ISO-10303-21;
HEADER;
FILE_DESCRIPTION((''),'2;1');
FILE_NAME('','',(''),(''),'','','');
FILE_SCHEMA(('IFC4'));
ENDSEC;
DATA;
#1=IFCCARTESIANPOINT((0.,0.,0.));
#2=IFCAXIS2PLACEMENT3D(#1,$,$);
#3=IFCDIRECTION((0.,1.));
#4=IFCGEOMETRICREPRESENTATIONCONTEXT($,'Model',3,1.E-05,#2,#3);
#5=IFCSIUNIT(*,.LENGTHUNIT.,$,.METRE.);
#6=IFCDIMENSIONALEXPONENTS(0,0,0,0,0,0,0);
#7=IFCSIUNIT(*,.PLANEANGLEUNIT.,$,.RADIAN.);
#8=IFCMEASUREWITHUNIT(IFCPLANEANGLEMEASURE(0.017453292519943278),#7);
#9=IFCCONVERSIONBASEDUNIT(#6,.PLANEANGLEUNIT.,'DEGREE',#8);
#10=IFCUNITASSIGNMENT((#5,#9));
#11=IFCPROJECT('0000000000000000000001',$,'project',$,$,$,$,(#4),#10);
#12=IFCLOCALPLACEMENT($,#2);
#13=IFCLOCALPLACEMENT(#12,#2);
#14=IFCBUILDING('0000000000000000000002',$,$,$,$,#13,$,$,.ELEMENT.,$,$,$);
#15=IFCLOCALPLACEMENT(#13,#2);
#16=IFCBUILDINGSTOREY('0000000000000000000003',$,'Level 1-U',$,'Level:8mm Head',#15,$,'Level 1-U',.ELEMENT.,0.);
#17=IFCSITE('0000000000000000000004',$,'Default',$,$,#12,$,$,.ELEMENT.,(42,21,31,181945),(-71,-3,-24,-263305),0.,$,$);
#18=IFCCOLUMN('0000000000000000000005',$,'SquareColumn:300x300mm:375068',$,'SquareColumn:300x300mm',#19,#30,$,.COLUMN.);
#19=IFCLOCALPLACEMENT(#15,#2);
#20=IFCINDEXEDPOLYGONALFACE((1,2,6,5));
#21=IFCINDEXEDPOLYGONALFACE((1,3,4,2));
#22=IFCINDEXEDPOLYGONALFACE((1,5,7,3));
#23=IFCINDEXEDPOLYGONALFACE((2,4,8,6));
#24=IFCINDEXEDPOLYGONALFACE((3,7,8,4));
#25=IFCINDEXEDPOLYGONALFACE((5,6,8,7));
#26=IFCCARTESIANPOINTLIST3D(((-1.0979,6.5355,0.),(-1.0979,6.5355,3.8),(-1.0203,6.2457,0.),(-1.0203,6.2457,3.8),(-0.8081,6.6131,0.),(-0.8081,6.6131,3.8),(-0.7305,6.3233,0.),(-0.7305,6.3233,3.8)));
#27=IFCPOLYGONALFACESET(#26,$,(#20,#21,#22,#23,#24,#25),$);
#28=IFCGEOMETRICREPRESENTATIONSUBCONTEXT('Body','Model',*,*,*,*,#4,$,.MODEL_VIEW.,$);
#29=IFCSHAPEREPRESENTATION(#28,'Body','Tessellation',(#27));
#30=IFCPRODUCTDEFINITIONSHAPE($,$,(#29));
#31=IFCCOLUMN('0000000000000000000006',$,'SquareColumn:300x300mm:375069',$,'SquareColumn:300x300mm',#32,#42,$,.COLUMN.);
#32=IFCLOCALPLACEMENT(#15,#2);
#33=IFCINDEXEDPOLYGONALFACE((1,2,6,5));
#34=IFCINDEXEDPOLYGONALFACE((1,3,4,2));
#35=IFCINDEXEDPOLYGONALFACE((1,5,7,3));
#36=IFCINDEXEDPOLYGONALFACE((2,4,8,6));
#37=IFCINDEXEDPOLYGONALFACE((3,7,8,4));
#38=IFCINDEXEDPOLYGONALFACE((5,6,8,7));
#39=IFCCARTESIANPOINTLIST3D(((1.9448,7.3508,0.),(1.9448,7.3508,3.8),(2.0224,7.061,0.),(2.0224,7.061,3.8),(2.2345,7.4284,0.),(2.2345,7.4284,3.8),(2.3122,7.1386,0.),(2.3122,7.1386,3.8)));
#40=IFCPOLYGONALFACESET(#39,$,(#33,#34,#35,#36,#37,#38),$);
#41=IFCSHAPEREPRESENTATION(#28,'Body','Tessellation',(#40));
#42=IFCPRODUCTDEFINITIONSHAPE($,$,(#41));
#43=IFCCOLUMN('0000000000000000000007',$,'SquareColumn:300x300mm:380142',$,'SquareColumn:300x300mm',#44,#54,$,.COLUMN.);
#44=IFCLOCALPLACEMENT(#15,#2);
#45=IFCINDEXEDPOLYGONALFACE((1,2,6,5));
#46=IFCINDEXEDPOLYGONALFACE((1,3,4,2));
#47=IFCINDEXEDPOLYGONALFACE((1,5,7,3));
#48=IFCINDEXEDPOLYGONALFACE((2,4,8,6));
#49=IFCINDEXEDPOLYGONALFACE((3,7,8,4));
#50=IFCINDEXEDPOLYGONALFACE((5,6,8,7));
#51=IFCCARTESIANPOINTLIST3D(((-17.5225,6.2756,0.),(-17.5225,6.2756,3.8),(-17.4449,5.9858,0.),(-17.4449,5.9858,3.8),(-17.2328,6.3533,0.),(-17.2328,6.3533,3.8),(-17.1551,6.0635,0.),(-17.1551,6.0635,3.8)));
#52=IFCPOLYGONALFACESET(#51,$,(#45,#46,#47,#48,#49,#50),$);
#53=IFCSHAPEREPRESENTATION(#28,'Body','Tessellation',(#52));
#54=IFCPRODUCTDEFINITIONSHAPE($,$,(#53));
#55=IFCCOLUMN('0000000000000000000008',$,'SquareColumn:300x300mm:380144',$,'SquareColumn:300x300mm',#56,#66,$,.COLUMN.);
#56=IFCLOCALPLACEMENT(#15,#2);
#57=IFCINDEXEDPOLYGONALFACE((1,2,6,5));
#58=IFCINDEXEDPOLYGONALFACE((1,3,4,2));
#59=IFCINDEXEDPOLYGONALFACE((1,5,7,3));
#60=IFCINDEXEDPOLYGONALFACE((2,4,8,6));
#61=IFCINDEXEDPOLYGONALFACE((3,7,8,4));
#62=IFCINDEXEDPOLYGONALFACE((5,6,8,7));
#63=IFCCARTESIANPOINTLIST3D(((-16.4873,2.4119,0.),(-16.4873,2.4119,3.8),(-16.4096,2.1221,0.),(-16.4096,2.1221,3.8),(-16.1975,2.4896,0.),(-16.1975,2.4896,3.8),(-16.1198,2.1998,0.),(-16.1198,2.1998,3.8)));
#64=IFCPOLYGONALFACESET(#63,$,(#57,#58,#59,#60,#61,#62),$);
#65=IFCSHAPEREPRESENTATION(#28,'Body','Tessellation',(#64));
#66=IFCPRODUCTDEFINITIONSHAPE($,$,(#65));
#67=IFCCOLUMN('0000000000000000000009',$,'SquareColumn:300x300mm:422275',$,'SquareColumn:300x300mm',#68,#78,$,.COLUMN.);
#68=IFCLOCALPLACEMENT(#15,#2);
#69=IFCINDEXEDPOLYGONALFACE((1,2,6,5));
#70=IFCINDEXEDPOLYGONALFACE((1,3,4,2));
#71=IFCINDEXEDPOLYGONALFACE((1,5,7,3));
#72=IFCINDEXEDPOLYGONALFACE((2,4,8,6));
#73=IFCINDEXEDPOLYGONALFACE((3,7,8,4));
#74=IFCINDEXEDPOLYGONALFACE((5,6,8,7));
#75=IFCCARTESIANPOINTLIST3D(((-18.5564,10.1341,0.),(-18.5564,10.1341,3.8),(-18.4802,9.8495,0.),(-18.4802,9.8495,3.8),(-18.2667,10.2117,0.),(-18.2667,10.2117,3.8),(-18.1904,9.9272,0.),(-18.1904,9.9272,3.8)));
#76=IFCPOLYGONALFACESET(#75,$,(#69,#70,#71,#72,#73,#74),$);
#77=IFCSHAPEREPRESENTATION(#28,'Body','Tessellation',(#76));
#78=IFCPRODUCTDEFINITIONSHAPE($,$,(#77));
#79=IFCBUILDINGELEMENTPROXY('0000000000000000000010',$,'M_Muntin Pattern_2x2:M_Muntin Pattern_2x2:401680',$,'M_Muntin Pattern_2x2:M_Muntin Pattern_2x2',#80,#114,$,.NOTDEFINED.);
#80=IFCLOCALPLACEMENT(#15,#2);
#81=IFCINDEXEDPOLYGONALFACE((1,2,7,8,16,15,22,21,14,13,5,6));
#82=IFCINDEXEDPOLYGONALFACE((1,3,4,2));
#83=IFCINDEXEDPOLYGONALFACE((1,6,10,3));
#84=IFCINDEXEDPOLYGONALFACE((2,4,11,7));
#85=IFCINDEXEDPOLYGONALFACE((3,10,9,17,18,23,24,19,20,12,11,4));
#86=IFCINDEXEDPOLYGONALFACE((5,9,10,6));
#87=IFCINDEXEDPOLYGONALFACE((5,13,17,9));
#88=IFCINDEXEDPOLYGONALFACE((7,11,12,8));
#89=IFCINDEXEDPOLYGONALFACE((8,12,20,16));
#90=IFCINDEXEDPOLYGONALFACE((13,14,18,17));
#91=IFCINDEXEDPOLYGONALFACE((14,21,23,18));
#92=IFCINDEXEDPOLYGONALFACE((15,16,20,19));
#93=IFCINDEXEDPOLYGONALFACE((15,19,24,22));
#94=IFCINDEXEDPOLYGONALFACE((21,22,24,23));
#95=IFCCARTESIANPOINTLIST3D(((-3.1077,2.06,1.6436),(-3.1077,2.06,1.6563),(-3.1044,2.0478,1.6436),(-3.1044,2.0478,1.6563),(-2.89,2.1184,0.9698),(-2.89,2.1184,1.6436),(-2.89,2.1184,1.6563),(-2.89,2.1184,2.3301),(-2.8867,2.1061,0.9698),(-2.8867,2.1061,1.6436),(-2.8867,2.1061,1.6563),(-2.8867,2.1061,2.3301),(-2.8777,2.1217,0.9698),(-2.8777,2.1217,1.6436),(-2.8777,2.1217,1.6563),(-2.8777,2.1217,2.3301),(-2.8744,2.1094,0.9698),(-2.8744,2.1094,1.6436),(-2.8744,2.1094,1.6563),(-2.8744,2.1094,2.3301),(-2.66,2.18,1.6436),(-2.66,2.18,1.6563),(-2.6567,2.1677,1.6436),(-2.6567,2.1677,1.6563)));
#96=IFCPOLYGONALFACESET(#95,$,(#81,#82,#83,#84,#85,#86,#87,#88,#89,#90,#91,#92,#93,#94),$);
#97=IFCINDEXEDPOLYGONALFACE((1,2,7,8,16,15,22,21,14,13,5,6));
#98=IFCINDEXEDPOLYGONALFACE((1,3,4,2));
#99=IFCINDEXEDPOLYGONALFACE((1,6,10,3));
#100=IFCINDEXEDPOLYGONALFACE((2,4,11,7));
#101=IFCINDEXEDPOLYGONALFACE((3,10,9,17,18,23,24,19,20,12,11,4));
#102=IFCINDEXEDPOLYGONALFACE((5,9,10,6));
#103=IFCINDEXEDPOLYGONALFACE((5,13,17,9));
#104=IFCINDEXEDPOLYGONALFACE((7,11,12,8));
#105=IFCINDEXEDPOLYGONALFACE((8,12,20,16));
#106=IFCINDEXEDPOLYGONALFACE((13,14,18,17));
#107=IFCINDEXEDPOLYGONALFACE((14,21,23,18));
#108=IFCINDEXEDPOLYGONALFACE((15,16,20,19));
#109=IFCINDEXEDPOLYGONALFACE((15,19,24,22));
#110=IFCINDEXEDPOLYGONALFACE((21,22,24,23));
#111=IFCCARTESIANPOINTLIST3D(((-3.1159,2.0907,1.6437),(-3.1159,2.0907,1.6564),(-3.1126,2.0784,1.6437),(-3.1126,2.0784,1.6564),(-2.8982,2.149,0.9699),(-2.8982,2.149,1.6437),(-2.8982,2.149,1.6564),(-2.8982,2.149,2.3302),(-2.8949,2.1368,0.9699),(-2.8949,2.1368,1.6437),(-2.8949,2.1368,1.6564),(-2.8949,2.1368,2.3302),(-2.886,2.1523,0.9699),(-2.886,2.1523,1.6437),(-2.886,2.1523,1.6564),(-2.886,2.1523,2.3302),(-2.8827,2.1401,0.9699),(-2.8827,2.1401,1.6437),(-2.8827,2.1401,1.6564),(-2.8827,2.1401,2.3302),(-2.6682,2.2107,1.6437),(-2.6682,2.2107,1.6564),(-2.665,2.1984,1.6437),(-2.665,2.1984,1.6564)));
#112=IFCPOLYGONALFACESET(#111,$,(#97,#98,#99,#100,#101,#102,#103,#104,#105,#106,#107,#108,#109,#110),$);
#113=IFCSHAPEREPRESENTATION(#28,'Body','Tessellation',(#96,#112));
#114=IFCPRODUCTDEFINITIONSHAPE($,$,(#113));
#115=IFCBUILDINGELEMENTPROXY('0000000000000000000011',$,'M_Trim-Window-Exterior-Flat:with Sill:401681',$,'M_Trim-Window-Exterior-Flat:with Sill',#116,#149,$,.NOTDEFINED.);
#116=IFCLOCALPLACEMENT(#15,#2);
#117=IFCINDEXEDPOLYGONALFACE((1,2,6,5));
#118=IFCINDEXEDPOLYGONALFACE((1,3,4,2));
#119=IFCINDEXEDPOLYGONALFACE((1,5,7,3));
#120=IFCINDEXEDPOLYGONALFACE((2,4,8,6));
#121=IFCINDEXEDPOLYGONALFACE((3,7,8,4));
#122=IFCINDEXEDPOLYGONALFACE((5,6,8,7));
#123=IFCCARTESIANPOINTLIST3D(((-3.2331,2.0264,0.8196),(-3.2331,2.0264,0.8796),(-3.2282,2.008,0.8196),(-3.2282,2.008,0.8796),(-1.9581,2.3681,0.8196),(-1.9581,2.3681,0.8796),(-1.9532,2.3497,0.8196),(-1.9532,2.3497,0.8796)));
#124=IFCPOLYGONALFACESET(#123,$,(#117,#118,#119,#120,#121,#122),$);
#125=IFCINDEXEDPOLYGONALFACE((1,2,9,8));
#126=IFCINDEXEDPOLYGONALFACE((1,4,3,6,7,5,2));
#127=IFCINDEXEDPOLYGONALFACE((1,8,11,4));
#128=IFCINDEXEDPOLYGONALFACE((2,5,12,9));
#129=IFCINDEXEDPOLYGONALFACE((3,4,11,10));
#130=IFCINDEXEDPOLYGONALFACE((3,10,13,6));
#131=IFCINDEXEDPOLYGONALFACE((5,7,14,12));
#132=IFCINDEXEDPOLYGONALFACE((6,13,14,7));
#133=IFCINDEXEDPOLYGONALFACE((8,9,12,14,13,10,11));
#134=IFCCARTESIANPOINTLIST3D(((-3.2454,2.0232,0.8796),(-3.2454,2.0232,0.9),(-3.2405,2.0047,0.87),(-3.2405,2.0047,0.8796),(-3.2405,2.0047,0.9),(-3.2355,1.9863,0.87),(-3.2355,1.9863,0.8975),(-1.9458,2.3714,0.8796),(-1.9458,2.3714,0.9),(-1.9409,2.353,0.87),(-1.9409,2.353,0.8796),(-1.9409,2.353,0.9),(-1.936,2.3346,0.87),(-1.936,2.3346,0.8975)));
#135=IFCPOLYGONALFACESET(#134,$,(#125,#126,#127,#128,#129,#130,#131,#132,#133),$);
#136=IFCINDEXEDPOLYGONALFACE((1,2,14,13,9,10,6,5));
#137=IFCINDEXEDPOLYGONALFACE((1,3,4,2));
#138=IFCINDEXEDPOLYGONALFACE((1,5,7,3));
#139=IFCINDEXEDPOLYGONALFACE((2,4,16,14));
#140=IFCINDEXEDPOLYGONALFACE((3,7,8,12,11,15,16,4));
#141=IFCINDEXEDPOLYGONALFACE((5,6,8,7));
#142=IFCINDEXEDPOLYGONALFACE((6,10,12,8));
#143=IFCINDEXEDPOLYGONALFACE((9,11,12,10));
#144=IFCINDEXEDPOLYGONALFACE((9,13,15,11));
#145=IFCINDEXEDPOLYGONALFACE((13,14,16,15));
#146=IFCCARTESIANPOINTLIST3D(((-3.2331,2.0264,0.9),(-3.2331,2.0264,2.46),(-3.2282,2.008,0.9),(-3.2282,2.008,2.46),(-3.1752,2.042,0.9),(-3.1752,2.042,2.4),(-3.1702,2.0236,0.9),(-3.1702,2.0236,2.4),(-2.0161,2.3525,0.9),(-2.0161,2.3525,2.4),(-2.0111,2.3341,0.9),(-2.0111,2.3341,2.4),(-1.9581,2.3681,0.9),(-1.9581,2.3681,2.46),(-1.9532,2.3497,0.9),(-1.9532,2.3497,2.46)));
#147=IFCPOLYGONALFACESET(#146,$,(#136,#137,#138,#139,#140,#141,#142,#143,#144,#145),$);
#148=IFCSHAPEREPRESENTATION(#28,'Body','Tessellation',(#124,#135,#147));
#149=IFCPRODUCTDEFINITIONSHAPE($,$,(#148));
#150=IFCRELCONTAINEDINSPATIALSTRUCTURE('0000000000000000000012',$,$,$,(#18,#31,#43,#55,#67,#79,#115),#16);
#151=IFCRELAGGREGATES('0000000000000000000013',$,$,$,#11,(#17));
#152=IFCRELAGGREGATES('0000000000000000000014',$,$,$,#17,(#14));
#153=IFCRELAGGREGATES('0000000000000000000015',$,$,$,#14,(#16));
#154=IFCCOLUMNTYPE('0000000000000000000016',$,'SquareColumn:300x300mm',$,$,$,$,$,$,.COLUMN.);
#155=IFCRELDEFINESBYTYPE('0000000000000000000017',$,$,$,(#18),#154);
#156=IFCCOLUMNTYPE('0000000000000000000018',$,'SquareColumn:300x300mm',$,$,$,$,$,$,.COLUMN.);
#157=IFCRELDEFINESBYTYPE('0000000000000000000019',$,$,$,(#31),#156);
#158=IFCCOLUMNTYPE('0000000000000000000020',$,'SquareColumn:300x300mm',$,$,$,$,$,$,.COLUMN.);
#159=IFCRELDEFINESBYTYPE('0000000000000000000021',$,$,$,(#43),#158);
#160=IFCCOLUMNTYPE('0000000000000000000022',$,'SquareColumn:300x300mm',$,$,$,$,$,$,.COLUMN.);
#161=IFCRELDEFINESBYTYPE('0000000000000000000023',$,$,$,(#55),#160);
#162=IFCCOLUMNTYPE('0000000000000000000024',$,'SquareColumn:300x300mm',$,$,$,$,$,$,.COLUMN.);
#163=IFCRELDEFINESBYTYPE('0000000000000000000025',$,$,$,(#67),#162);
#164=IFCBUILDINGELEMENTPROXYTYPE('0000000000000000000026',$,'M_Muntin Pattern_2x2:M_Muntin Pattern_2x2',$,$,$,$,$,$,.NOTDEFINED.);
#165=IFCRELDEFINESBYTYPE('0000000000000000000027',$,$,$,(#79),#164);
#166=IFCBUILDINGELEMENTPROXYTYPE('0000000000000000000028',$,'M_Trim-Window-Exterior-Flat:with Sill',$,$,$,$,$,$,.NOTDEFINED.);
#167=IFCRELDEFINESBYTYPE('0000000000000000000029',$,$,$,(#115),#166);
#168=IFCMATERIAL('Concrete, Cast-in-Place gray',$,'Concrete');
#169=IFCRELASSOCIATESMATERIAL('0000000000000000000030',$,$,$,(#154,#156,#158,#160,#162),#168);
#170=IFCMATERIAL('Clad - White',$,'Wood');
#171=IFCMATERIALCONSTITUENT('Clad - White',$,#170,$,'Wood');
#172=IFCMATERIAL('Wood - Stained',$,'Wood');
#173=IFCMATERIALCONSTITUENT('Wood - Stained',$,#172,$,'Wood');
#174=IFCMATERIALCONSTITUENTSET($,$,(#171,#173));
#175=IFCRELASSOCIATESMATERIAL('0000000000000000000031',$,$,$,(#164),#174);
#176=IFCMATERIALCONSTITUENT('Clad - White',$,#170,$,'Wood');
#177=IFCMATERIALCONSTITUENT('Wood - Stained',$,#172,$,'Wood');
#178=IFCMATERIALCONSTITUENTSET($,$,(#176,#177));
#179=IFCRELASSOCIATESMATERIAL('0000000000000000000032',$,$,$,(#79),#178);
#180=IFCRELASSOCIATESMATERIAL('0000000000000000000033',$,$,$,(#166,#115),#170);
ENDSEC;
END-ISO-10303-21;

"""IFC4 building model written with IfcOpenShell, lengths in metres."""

from ifc_helpers import new_model, entity, si_unit, converted_unit, direction, frame, frame_2d, origin, origin_2d_with_axis, place, context, subcontext, project, spatial, polyline, rectangle, outline, extrude, source, transform, mapped, material, constituent, constituent_set, material_profile, profile_set, type_object, type_shapes, element, save


model = new_model("IFC4")

# Units and contexts
model_context = context("Model", 3, precision=1e-05, world=origin(), true_north=direction((0.0, 1.0)))
body_context = subcontext(model_context, "Body", "Model", "MODEL_VIEW")
ifc_project = project(units=[si_unit("LENGTHUNIT", "METRE"), converted_unit("PLANEANGLEUNIT", "DEGREE", entity("IfcPlaneAngleMeasure", 0.017453292519943278), si_unit("PLANEANGLEUNIT", "RADIAN"), dimensions=[0, 0, 0, 0, 0, 0, 0])], contexts=[model_context])

# Site, building, storey
site_placement = place(None, origin())
site = spatial("IfcSite", under=ifc_project, at=site_placement, Name="Default", CompositionType="ELEMENT", RefLatitude=(42, 21, 31, 181945), RefLongitude=(-71, -3, -24, -263305), RefElevation=0.0)
building_placement = place(site_placement, origin())
building = spatial("IfcBuilding", under=site, at=building_placement, CompositionType="ELEMENT")
storey_placement = place(building_placement, origin())
storey = spatial("IfcBuildingStorey", under=building, at=storey_placement, Name="Level 1-U", ObjectType="Level:8mm Head", LongName="Level 1-U", CompositionType="ELEMENT", Elevation=0.0)

# Columns
ifc_material_1 = material(Name="Concrete, Cast-in-Place gray", Category="Concrete")
ifc_material_profile = material_profile(ifc_material_1, rectangle(XDim=0.3, YDim=0.3, at=origin_2d_with_axis()), Name="300x300mm")
ifc_profile_set = profile_set([ifc_material_profile], Name="300x300mm")
column_type_1 = type_object("IfcColumnType", Name="SquareColumn:300x300mm", PredefinedType="COLUMN", material=ifc_profile_set)
shared_shape_1 = source(origin(), body_context, "Body", "SweptSolid", [
    extrude(rectangle(XDim=0.3, YDim=0.3, at=frame_2d((0.0, 0.0), x_axis=(1.0, 0.0))), frame((-0.9142, 6.4294, 0.0), z_axis=(0.0, 0.0, 1.0), x_axis=(-0.258819, 0.965926, 0.0)), (0.0, 0.0, 1.0), 3.8),
])
type_shapes(column_type_1, [shared_shape_1])
column_1_placement = place(storey_placement, origin())
element("IfcColumn", 1, at=column_1_placement, inside=storey, type_object=column_type_1, Name="SquareColumn:300x300mm:375068", ObjectType="SquareColumn:300x300mm", PredefinedType="COLUMN", context=body_context, shape_type="MappedRepresentation", body=[
    mapped(shared_shape_1, transform((0.0, 0.0, 0.0), scale=1.0)),
])
column_type_2 = type_object("IfcColumnType", Name="SquareColumn:300x300mm", PredefinedType="COLUMN", material=ifc_profile_set)
shared_shape_2 = source(origin(), body_context, "Body", "SweptSolid", [
    extrude(rectangle(XDim=0.3, YDim=0.3, at=frame_2d((0.0, 0.0), x_axis=(1.0, 0.0))), frame((2.1285, 7.2447, 0.0), z_axis=(0.0, 0.0, 1.0), x_axis=(-0.258819, 0.965926, 0.0)), (0.0, 0.0, 1.0), 3.8),
])
type_shapes(column_type_2, [shared_shape_2])
column_2_placement = place(storey_placement, origin())
element("IfcColumn", 2, at=column_2_placement, inside=storey, type_object=column_type_2, Name="SquareColumn:300x300mm:375069", ObjectType="SquareColumn:300x300mm", PredefinedType="COLUMN", context=body_context, shape_type="MappedRepresentation", body=[
    mapped(shared_shape_2, transform((0.0, 0.0, 0.0), scale=1.0)),
])
column_type_3 = type_object("IfcColumnType", Name="SquareColumn:300x300mm", PredefinedType="COLUMN", material=ifc_profile_set)
shared_shape_3 = source(origin(), body_context, "Body", "SweptSolid", [
    extrude(rectangle(XDim=0.3, YDim=0.3, at=origin_2d_with_axis()), frame((-17.3388, 6.1695, 0.0), z_axis=(0.0, 0.0, 1.0), x_axis=(-0.258819, 0.965926, 0.0)), (0.0, 0.0, 1.0), 3.8),
])
type_shapes(column_type_3, [shared_shape_3])
column_3_placement = place(storey_placement, origin())
element("IfcColumn", 3, at=column_3_placement, inside=storey, type_object=column_type_3, Name="SquareColumn:300x300mm:380142", ObjectType="SquareColumn:300x300mm", PredefinedType="COLUMN", context=body_context, shape_type="MappedRepresentation", body=[
    mapped(shared_shape_3, transform((0.0, 0.0, 0.0), scale=1.0)),
])
column_type_4 = type_object("IfcColumnType", Name="SquareColumn:300x300mm", PredefinedType="COLUMN", material=ifc_profile_set)
shared_shape_4 = source(origin(), body_context, "Body", "SweptSolid", [
    extrude(rectangle(XDim=0.3, YDim=0.3, at=origin_2d_with_axis()), frame((-16.3036, 2.3058, 0.0), z_axis=(0.0, 0.0, 1.0), x_axis=(-0.258819, 0.965926, 0.0)), (0.0, 0.0, 1.0), 3.8),
])
type_shapes(column_type_4, [shared_shape_4])
column_4_placement = place(storey_placement, origin())
element("IfcColumn", 4, at=column_4_placement, inside=storey, type_object=column_type_4, Name="SquareColumn:300x300mm:380144", ObjectType="SquareColumn:300x300mm", PredefinedType="COLUMN", context=body_context, shape_type="MappedRepresentation", body=[
    mapped(shared_shape_4, transform((0.0, 0.0, 0.0), scale=1.0)),
])
column_type_5 = type_object("IfcColumnType", Name="SquareColumn:300x300mm", PredefinedType="COLUMN", material=ifc_profile_set)
shared_shape_5 = source(origin(), body_context, "Body", "SweptSolid", [
    extrude(rectangle(XDim=0.2946, YDim=0.3, at=frame_2d((0.0, 0.0), x_axis=(1.0, 0.0))), frame((-18.3734, 10.0306, 0.0), z_axis=(0.0, 0.0, 1.0), x_axis=(-0.258819, 0.965926, 0.0)), (0.0, 0.0, 1.0), 3.8),
])
type_shapes(column_type_5, [shared_shape_5])
column_5_placement = place(storey_placement, origin())
element("IfcColumn", 5, at=column_5_placement, inside=storey, type_object=column_type_5, Name="SquareColumn:300x300mm:422275", ObjectType="SquareColumn:300x300mm", PredefinedType="COLUMN", context=body_context, shape_type="MappedRepresentation", body=[
    mapped(shared_shape_5, transform((0.0, 0.0, 0.0), scale=1.0)),
])

# Building element proxies
ifc_material_2 = material(Name="Clad - White", Category="Wood")
ifc_constituent_1 = constituent(ifc_material_2, Name="Clad - White", Category="Wood")
ifc_material_3 = material(Name="Wood - Stained", Category="Wood")
ifc_constituent_2 = constituent(ifc_material_3, Name="Wood - Stained", Category="Wood")
ifc_constituent_set_1 = constituent_set(constituents=[ifc_constituent_1, ifc_constituent_2])
ifc_constituent_3 = constituent(ifc_material_2, Name="Clad - White", Category="Wood")
ifc_constituent_4 = constituent(ifc_material_3, Name="Wood - Stained", Category="Wood")
ifc_constituent_set_2 = constituent_set(constituents=[ifc_constituent_3, ifc_constituent_4])
building_element_proxy_type_1 = type_object("IfcBuildingElementProxyType", Name="M_Muntin Pattern_2x2:M_Muntin Pattern_2x2", PredefinedType="NOTDEFINED", material=ifc_constituent_set_2)
shared_shape_6 = source(origin(), body_context, "Body", "SweptSolid", [
    extrude(outline(polyline([(0.0064, -0.0064), (0.6801, -0.0064), (0.6801, 0.0063), (0.0064, 0.0063), (0.0064, 0.2317), (-0.0063, 0.2317), (-0.0063, 0.0063), (-0.6802, 0.0063), (-0.6802, -0.0064), (-0.0063, -0.0064), (-0.0063, -0.2317), (0.0064, -0.2317), (0.0064, -0.0064)])), frame((0.0, -0.0222, 0.6801), z_axis=(0.0, 1.0, 0.0), x_axis=(0.0, 0.0, 1.0)), (0.0, 0.0, 1.0), 0.0127),
    extrude(outline(polyline([(0.0064, -0.0064), (0.6802, -0.0064), (0.6802, 0.0063), (0.0064, 0.0063), (0.0064, 0.2317), (-0.0063, 0.2317), (-0.0063, 0.0063), (-0.6802, 0.0063), (-0.6802, -0.0064), (-0.0063, -0.0064), (-0.0063, -0.2317), (0.0064, -0.2317), (0.0064, -0.0064)])), frame((0.0, 0.0095, 0.6802), z_axis=(0.0, 1.0, 0.0), x_axis=(0.0, 0.0, 1.0)), (0.0, 0.0, 1.0), 0.0127),
])
type_shapes(building_element_proxy_type_1, [shared_shape_6])
proxy_1_placement = place(storey_placement, frame((-2.8863, 2.1292, 0.9699), z_axis=(0.0, 0.0, 1.0), x_axis=(0.965926, 0.258819, 0.0)))
element("IfcBuildingElementProxy", 6, at=proxy_1_placement, inside=storey, type_object=building_element_proxy_type_1, material=ifc_constituent_set_1, Name="M_Muntin Pattern_2x2:M_Muntin Pattern_2x2:401680", ObjectType="M_Muntin Pattern_2x2:M_Muntin Pattern_2x2", PredefinedType="NOTDEFINED", context=body_context, shape_type="MappedRepresentation", body=[
    mapped(shared_shape_6, transform((0.0, 0.0, 0.0), scale=1.0)),
])
building_element_proxy_type_2 = type_object("IfcBuildingElementProxyType", Name="M_Trim-Window-Exterior-Flat:with Sill", PredefinedType="NOTDEFINED", material=ifc_material_2)
shared_shape_7 = source(origin(), body_context, "Body", "SweptSolid", [
    extrude(rectangle(XDim=1.32, YDim=0.06, at=frame_2d((0.0, 0.0), x_axis=(1.0, 0.0))), frame((0.0, -1.5504, 0.0), z_axis=(0.0, 0.0, 1.0), x_axis=(-1.0, 0.0, 0.0)), (0.0, 0.0, 1.0), 0.019),
    extrude(outline(polyline([(-0.019, -0.0152), (0.0, -0.0152), (0.0, -0.0057), (0.019, -0.0057), (0.019, 0.0148), (0.0, 0.0148), (-0.019, 0.0123), (-0.019, -0.0152)])), frame((-0.6727, -1.5148, 0.019), z_axis=(1.0, 0.0, 0.0), x_axis=(0.0, 0.0, -1.0)), (0.0, 0.0, 1.0), 1.3454),
    extrude(outline(polyline([(-0.795, -0.66), (0.765, -0.66), (0.765, -0.6), (-0.735, -0.6), (-0.735, 0.6), (0.765, 0.6), (0.765, 0.66), (-0.795, 0.66), (-0.795, -0.66)])), frame((0.0, -0.735, 0.0), z_axis=(0.0, 0.0, 1.0), x_axis=(0.0, -1.0, 0.0)), (0.0, 0.0, 1.0), 0.019),
])
type_shapes(building_element_proxy_type_2, [shared_shape_7])
proxy_2_placement = place(storey_placement, frame((-2.5956, 2.1973, 2.4), z_axis=(0.258819, -0.965926, 0.0), x_axis=(0.965926, 0.258819, 0.0)))
element("IfcBuildingElementProxy", 7, at=proxy_2_placement, inside=storey, type_object=building_element_proxy_type_2, material=ifc_material_2, Name="M_Trim-Window-Exterior-Flat:with Sill:401681", ObjectType="M_Trim-Window-Exterior-Flat:with Sill", PredefinedType="NOTDEFINED", context=body_context, shape_type="MappedRepresentation", body=[
    mapped(shared_shape_7, transform((0.0, 0.0, 0.0), scale=1.0)),
])

save(model, "model.ifc")
